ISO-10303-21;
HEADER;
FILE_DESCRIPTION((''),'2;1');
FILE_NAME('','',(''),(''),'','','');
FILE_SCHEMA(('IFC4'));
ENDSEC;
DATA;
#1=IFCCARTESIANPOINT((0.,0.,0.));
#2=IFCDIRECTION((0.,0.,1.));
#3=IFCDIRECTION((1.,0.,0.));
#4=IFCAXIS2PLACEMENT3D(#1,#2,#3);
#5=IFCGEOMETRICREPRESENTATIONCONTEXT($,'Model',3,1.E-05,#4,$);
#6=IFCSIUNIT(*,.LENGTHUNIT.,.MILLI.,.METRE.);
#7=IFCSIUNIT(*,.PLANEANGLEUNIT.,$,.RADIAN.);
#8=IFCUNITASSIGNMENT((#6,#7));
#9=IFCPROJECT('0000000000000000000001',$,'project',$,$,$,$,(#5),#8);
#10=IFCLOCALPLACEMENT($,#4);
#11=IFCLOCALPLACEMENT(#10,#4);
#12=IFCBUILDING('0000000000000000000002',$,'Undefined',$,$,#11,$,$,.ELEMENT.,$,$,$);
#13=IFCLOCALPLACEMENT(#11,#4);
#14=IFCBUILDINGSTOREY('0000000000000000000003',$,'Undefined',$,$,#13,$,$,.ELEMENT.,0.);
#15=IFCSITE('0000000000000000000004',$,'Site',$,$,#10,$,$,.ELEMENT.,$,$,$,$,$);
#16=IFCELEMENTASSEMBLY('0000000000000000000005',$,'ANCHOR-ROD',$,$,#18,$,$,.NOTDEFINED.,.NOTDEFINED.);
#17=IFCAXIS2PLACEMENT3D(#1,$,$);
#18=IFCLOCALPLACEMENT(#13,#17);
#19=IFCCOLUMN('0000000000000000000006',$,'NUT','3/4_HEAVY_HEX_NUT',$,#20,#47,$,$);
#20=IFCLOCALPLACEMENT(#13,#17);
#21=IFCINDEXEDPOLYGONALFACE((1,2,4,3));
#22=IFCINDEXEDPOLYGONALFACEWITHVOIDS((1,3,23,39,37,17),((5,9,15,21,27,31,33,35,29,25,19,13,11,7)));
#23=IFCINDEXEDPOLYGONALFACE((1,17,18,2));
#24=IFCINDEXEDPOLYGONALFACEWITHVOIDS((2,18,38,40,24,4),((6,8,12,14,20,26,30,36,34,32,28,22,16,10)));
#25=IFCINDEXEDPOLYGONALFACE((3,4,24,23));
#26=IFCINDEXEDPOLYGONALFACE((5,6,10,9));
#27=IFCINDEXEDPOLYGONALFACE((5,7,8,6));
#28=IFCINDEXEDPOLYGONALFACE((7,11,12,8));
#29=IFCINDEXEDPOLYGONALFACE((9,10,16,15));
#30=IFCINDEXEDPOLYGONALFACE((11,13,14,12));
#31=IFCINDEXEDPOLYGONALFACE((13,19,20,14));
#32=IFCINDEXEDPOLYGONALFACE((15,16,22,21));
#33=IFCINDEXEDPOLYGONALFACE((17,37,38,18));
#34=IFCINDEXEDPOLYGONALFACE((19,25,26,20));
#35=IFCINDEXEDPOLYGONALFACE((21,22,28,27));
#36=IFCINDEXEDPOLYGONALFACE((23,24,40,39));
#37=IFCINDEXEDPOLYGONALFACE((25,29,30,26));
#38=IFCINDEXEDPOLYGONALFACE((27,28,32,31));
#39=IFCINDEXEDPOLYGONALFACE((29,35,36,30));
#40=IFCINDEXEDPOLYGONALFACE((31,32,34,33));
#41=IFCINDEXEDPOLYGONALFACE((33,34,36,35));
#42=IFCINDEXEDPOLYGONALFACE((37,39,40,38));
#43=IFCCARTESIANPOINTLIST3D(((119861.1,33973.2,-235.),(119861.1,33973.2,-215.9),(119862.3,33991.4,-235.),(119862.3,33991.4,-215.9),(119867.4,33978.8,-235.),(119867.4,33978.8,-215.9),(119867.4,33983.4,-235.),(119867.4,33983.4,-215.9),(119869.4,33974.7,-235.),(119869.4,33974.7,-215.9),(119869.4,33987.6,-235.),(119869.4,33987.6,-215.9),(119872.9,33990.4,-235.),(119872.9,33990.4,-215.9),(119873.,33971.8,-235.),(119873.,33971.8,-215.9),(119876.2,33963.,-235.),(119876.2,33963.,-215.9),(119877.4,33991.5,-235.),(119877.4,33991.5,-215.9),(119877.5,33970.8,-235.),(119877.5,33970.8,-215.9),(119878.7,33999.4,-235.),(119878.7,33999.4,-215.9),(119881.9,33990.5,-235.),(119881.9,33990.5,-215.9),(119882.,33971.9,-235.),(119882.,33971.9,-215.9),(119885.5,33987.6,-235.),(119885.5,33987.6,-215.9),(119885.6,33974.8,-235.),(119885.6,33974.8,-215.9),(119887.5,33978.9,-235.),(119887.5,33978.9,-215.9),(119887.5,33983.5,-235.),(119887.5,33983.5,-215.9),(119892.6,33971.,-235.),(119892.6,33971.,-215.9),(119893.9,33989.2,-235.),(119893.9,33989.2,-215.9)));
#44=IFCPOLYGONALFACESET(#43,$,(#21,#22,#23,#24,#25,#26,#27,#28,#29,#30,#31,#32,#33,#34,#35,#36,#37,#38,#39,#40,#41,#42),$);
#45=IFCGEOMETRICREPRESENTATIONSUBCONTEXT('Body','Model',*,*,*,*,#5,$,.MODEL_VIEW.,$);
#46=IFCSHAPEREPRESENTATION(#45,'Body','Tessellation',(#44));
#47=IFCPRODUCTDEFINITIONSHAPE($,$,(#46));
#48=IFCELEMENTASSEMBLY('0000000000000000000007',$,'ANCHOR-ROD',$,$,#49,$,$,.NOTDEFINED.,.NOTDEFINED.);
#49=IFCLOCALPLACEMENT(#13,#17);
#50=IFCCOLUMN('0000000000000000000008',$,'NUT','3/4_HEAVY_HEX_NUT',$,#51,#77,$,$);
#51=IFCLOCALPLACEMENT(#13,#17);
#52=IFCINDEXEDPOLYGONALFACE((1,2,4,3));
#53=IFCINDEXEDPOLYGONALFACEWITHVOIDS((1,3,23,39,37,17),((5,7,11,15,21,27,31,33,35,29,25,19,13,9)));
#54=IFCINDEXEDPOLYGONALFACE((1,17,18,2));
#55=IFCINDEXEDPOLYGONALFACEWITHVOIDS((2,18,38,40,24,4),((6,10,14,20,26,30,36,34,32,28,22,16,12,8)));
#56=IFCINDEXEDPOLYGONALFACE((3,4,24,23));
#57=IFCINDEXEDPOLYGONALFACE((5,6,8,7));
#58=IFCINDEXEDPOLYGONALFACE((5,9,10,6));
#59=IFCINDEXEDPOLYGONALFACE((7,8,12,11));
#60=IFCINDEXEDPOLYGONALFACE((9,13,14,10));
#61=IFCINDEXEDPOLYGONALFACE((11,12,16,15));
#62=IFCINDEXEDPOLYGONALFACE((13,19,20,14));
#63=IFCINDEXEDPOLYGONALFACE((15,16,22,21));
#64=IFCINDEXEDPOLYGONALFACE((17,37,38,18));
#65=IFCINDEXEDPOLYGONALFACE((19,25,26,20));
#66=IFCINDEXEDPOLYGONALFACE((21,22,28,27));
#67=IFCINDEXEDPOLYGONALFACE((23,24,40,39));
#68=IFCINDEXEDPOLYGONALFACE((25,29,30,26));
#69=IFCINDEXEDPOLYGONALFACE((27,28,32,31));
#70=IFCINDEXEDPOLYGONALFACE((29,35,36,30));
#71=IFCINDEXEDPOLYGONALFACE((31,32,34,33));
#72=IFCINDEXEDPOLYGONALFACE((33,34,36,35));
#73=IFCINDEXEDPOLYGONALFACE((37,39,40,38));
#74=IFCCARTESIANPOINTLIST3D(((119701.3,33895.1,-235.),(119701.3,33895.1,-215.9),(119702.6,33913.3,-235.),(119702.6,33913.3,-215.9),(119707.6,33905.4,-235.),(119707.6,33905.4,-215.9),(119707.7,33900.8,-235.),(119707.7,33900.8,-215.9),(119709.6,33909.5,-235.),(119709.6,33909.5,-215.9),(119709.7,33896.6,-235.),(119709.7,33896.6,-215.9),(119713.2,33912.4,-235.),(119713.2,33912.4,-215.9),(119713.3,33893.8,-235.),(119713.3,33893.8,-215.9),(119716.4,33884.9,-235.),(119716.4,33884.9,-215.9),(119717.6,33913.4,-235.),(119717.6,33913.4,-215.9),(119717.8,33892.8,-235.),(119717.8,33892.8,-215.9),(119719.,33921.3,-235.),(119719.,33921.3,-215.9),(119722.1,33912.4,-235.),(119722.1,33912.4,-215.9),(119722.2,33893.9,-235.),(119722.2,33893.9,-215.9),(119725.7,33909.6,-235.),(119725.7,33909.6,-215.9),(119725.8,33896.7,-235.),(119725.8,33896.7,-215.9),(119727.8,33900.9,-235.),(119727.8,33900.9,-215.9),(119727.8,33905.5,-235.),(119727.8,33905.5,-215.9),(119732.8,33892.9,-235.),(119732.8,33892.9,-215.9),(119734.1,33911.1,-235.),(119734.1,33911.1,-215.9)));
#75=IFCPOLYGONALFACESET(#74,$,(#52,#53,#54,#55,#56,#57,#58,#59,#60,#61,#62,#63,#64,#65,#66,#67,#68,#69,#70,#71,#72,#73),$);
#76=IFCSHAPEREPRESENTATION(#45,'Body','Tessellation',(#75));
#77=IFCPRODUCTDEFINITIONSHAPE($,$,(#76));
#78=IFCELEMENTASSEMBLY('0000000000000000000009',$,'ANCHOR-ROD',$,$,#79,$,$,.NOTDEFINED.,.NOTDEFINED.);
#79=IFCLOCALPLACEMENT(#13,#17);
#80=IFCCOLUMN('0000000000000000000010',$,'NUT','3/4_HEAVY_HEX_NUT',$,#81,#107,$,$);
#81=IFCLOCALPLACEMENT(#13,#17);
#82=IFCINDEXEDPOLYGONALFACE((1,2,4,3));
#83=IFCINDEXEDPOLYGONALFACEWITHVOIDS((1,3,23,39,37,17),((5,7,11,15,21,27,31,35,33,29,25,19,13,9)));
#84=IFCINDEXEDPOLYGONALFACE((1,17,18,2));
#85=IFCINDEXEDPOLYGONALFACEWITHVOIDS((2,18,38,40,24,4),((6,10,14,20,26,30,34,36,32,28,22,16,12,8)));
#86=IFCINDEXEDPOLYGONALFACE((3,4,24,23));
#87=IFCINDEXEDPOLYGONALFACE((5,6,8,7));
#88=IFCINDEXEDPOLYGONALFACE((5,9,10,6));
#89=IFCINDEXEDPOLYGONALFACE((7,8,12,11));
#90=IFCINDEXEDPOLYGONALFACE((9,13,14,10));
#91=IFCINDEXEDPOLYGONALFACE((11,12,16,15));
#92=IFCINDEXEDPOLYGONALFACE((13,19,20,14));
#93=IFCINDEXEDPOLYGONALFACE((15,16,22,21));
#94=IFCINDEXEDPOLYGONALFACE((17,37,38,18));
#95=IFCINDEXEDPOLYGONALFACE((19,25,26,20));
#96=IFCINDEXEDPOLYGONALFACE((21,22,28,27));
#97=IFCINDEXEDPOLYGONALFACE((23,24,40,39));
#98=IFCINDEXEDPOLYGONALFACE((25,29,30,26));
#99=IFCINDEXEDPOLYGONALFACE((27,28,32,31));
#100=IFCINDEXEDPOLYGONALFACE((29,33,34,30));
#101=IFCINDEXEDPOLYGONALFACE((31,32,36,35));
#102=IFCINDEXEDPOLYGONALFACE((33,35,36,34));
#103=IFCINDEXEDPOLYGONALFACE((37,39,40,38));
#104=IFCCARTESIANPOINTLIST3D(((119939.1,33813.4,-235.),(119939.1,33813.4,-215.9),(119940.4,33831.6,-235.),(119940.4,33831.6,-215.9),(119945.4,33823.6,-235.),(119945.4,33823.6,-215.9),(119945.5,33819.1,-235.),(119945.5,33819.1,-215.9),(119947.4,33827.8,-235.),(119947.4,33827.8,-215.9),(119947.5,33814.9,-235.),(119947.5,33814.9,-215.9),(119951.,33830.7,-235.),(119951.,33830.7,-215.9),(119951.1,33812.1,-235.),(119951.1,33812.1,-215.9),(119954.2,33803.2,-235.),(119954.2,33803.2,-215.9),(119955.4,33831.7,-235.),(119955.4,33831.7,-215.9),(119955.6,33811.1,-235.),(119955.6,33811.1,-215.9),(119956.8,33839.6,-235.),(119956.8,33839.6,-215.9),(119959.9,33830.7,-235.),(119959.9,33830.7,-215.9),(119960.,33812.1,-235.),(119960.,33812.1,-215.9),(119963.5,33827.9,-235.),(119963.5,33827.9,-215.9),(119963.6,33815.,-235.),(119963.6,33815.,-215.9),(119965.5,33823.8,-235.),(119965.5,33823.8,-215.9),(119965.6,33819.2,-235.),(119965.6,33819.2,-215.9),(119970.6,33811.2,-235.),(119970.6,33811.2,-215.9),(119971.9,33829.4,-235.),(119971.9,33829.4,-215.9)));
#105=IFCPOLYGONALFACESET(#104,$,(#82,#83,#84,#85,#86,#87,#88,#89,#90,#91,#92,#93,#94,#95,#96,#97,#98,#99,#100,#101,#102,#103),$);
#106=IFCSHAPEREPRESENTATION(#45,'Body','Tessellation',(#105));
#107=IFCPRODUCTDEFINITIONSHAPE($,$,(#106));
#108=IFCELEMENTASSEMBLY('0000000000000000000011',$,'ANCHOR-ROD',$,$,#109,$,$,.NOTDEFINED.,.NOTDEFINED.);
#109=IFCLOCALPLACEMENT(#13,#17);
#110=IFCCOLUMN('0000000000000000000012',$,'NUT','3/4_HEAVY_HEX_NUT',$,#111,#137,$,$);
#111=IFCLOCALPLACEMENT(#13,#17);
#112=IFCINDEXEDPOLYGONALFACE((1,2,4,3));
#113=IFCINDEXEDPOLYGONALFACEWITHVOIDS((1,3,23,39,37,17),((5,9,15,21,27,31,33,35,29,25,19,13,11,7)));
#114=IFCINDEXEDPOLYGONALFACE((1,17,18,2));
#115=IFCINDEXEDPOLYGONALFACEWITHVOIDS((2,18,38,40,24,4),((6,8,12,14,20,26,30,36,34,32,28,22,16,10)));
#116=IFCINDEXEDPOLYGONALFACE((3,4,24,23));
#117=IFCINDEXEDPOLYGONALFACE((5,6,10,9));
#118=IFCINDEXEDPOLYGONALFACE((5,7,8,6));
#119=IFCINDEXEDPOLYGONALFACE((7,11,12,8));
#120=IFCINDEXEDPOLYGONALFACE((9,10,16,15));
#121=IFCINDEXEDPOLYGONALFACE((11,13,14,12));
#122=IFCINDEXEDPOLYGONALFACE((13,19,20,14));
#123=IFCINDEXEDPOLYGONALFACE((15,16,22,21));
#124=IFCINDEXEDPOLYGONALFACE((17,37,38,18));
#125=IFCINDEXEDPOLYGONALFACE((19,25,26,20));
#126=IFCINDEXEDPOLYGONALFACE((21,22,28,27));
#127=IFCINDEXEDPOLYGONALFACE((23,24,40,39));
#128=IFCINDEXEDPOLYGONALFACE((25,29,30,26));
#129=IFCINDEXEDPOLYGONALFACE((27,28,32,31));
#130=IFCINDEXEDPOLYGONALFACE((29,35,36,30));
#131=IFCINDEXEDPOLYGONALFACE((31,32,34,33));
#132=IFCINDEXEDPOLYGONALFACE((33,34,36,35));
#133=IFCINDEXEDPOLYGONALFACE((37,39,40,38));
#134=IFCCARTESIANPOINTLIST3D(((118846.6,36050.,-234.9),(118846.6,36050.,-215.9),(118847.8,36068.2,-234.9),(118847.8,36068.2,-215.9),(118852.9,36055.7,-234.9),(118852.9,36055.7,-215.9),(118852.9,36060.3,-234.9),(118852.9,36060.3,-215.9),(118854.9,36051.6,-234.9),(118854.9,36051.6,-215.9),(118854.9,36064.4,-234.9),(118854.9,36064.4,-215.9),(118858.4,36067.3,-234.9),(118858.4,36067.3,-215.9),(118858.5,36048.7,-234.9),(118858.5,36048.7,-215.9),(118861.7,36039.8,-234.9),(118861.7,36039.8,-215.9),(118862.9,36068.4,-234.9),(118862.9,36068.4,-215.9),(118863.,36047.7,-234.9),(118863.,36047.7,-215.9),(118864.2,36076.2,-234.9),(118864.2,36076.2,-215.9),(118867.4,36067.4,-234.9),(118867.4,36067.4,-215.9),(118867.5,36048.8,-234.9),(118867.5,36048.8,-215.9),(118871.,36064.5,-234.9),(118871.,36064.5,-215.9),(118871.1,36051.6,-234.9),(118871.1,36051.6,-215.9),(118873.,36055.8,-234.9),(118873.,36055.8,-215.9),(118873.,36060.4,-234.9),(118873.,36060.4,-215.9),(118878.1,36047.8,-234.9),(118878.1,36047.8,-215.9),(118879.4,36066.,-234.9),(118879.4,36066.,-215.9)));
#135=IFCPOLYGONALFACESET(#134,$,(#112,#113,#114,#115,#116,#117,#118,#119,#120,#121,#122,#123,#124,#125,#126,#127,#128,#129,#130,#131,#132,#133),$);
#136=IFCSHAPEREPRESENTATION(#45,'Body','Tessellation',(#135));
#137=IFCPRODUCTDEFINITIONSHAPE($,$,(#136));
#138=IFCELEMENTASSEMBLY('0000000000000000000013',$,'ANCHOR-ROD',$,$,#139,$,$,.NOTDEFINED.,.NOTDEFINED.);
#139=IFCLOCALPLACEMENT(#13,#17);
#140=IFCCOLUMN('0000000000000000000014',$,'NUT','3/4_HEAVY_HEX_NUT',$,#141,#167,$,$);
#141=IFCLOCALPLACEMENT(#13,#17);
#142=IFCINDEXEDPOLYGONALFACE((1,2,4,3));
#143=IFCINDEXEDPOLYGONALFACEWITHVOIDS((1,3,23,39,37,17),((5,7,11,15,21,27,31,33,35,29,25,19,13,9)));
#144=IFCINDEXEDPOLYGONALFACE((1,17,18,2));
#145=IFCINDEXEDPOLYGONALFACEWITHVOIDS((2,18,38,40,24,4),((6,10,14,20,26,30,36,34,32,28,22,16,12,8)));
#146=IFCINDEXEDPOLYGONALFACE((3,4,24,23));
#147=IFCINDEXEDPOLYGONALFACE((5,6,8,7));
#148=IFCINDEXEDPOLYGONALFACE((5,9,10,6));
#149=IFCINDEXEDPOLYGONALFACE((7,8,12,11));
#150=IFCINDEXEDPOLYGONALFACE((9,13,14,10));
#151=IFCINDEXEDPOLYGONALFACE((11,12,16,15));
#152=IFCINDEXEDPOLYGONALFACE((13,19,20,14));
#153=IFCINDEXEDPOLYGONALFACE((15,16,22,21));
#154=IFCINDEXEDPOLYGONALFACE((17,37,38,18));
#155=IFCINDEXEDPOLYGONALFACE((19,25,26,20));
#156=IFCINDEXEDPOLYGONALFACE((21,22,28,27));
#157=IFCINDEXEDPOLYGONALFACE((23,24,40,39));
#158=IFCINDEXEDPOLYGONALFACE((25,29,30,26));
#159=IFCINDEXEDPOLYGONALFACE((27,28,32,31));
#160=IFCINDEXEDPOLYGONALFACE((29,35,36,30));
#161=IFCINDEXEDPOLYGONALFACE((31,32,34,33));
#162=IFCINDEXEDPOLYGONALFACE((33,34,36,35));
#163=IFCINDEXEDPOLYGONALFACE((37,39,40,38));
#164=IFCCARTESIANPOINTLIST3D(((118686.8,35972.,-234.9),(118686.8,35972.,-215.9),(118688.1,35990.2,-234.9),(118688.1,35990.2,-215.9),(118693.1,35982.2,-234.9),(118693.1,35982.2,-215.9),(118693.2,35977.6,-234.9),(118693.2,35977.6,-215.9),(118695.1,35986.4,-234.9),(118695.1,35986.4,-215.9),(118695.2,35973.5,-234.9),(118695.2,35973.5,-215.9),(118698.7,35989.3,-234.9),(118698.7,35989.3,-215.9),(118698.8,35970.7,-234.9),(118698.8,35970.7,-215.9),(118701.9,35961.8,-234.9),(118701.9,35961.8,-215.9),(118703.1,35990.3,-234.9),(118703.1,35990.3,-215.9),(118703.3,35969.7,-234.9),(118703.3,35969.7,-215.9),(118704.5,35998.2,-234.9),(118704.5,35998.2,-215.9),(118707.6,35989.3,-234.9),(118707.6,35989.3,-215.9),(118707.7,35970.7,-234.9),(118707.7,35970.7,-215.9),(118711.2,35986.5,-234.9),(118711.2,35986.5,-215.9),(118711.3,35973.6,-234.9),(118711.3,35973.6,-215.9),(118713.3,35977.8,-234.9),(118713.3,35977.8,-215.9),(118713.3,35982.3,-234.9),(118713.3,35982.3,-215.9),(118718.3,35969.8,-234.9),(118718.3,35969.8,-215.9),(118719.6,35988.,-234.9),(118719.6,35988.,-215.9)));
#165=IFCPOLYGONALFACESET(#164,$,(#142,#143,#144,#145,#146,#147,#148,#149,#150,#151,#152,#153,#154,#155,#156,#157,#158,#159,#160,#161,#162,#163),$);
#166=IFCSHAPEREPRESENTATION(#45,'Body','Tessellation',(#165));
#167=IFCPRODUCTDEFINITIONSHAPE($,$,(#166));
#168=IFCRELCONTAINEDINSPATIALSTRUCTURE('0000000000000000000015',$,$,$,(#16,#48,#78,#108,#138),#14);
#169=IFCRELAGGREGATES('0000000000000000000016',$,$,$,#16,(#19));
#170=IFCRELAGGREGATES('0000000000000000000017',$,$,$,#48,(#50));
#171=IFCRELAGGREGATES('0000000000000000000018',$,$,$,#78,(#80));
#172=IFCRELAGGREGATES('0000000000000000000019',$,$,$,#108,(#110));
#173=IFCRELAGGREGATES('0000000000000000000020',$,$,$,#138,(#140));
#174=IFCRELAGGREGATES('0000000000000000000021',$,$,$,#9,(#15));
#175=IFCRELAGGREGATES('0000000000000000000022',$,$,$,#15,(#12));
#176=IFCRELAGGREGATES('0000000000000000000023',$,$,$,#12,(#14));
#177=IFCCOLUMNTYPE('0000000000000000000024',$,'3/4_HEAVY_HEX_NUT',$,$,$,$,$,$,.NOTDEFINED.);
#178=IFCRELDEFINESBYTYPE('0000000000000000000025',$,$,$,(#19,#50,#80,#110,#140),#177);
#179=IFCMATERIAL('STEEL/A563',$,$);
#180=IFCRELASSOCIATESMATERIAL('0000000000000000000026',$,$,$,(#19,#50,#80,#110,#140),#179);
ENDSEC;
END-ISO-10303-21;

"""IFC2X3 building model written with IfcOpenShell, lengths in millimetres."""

from ifc_helpers import new_model, si_unit, frame, origin_with_axes, place, context, subcontext, project, spatial, polyline, outline, extrude, material, type_object, element, aggregate, save


model = new_model("IFC2X3")

# Units and contexts
model_context = context("Model", 3, precision=1e-05, world=origin_with_axes())
body_context = subcontext(model_context, "Body", "Model", "MODEL_VIEW")
ifc_project = project(units=[si_unit("LENGTHUNIT", "METRE", prefix="MILLI"), si_unit("PLANEANGLEUNIT", "RADIAN")], contexts=[model_context])

# Site, building, storey
site_placement = place(None, origin_with_axes())
site = spatial("IfcSite", under=ifc_project, at=site_placement, Name="Site", CompositionType="ELEMENT")
building_placement = place(site_placement, origin_with_axes())
building = spatial("IfcBuilding", under=site, at=building_placement, Name="Undefined", CompositionType="ELEMENT")
storey_placement = place(building_placement, origin_with_axes())
storey = spatial("IfcBuildingStorey", under=building, at=storey_placement, Name="Undefined", CompositionType="ELEMENT", Elevation=0.0)

# Element assemblies, columns
assembly_1_placement = place(storey_placement, origin_with_axes())
assembly_1 = element("IfcElementAssembly", 1, at=assembly_1_placement, inside=storey, Name="ANCHOR-ROD", AssemblyPlace="NOTDEFINED", PredefinedType="NOTDEFINED")
ifc_material_1 = material(Name="STEEL/A563")
column_type_1 = type_object("IfcColumnType", Name="3/4_HEAVY_HEX_NUT", PredefinedType="NOTDEFINED")
column_1_placement = place(assembly_1_placement, frame((119877.5, 33981.2, -215.9), z_axis=(0.0, 0.0, -1.0), x_axis=(-0.438909, 0.898531, 0.0)))
column_1 = element("IfcColumn", 2, at=column_1_placement, type_object=column_type_1, material=ifc_material_1, Name="NUT", Description="3/4_HEAVY_HEX_NUT", context=body_context, shape_type="SweptSolid", body=[
    extrude(outline(polyline([(-9.1, 15.8), (9.1, 15.8), (18.3, 0.0), (9.1, -15.8), (-9.1, -15.8), (-18.3, 0.0), (-9.1, 15.8)]), holes=[polyline([(8.1, -6.4), (10.1, -2.3), (10.1, 2.3), (8.1, 6.4), (4.5, 9.3), (0.0, 10.3), (-4.5, 9.3), (-8.1, 6.4), (-10.1, 2.3), (-10.1, -2.3), (-8.1, -6.4), (-4.5, -9.3), (0.0, -10.3), (4.5, -9.3), (8.1, -6.4)])]), frame((0.0, 0.0, 19.1), z_axis=(0.0, 0.0, -1.0), x_axis=(0.0, 1.0, 0.0)), (0.0, 0.0, 1.0), 19.1),
])
aggregate(assembly_1, [column_1])
assembly_2_placement = place(storey_placement, origin_with_axes())
assembly_2 = element("IfcElementAssembly", 3, at=assembly_2_placement, inside=storey, Name="ANCHOR-ROD", AssemblyPlace="NOTDEFINED", PredefinedType="NOTDEFINED")
column_2_placement = place(assembly_2_placement, frame((119717.7, 33903.1, -215.9), z_axis=(0.0, 0.0, -1.0), x_axis=(0.438909, -0.898531, 0.0)))
column_2 = element("IfcColumn", 4, at=column_2_placement, type_object=column_type_1, material=ifc_material_1, Name="NUT", Description="3/4_HEAVY_HEX_NUT", context=body_context, shape_type="SweptSolid", body=[
    extrude(outline(polyline([(-9.1, 15.8), (9.1, 15.8), (18.3, 0.0), (9.1, -15.8), (-9.1, -15.8), (-18.3, 0.0), (-9.1, 15.8)]), holes=[polyline([(8.1, -6.4), (10.1, -2.3), (10.1, 2.3), (8.1, 6.4), (4.5, 9.3), (0.0, 10.3), (-4.5, 9.3), (-8.1, 6.4), (-10.1, 2.3), (-10.1, -2.3), (-8.1, -6.4), (-4.5, -9.3), (0.0, -10.3), (4.5, -9.3), (8.1, -6.4)])]), frame((0.0, 0.0, 19.1), z_axis=(0.0, 0.0, -1.0), x_axis=(0.0, 1.0, 0.0)), (0.0, 0.0, 1.0), 19.1),
])
aggregate(assembly_2, [column_2])
assembly_3_placement = place(storey_placement, origin_with_axes())
assembly_3 = element("IfcElementAssembly", 5, at=assembly_3_placement, inside=storey, Name="ANCHOR-ROD", AssemblyPlace="NOTDEFINED", PredefinedType="NOTDEFINED")
column_3_placement = place(assembly_3_placement, frame((119955.5, 33821.4, -215.9), z_axis=(0.0, 0.0, -1.0), x_axis=(-0.438909, 0.898531, 0.0)))
column_3 = element("IfcColumn", 6, at=column_3_placement, type_object=column_type_1, material=ifc_material_1, Name="NUT", Description="3/4_HEAVY_HEX_NUT", context=body_context, shape_type="SweptSolid", body=[
    extrude(outline(polyline([(-9.1, 15.8), (9.1, 15.8), (18.3, 0.0), (9.1, -15.8), (-9.1, -15.8), (-18.3, 0.0), (-9.1, 15.8)]), holes=[polyline([(8.1, -6.4), (10.1, -2.3), (10.1, 2.3), (8.1, 6.4), (4.5, 9.3), (0.0, 10.3), (-4.5, 9.3), (-8.1, 6.4), (-10.1, 2.3), (-10.1, -2.3), (-8.1, -6.4), (-4.5, -9.3), (0.0, -10.3), (4.5, -9.3), (8.1, -6.4)])]), frame((0.0, 0.0, 19.1), z_axis=(0.0, 0.0, -1.0), x_axis=(0.0, 1.0, 0.0)), (0.0, 0.0, 1.0), 19.1),
])
aggregate(assembly_3, [column_3])
assembly_4_placement = place(storey_placement, origin_with_axes())
assembly_4 = element("IfcElementAssembly", 7, at=assembly_4_placement, inside=storey, Name="ANCHOR-ROD", AssemblyPlace="NOTDEFINED", PredefinedType="NOTDEFINED")
column_4_placement = place(assembly_4_placement, frame((118863.0, 36058.0, -215.9), z_axis=(0.0, 0.0, -1.0), x_axis=(-0.438909, 0.898531, 0.0)))
column_4 = element("IfcColumn", 8, at=column_4_placement, type_object=column_type_1, material=ifc_material_1, Name="NUT", Description="3/4_HEAVY_HEX_NUT", context=body_context, shape_type="SweptSolid", body=[
    extrude(outline(polyline([(-9.1, 15.8), (9.1, 15.8), (18.3, 0.0), (9.1, -15.8), (-9.1, -15.8), (-18.3, 0.0), (-9.1, 15.8)]), holes=[polyline([(8.1, -6.4), (10.1, -2.3), (10.1, 2.3), (8.1, 6.4), (4.5, 9.3), (0.0, 10.3), (-4.5, 9.3), (-8.1, 6.4), (-10.1, 2.3), (-10.1, -2.3), (-8.1, -6.4), (-4.5, -9.3), (0.0, -10.3), (4.5, -9.3), (8.1, -6.4)])]), frame((0.0, 0.0, 19.1), z_axis=(0.0, 0.0, -1.0), x_axis=(0.0, 1.0, 0.0)), (0.0, 0.0, 1.0), 19.1),
])
assembly_5_placement = place(storey_placement, origin_with_axes())
assembly_5 = element("IfcElementAssembly", 9, at=assembly_5_placement, inside=storey, Name="ANCHOR-ROD", AssemblyPlace="NOTDEFINED", PredefinedType="NOTDEFINED")
column_5_placement = place(assembly_5_placement, frame((118703.2, 35980.0, -215.9), z_axis=(0.0, 0.0, -1.0), x_axis=(0.438909, -0.898531, 0.0)))
column_5 = element("IfcColumn", 10, at=column_5_placement, type_object=column_type_1, material=ifc_material_1, Name="NUT", Description="3/4_HEAVY_HEX_NUT", context=body_context, shape_type="SweptSolid", body=[
    extrude(outline(polyline([(-9.1, 15.8), (9.1, 15.8), (18.3, 0.0), (9.1, -15.8), (-9.1, -15.8), (-18.3, 0.0), (-9.1, 15.8)]), holes=[polyline([(8.1, -6.4), (10.1, -2.3), (10.1, 2.3), (8.1, 6.4), (4.5, 9.3), (0.0, 10.3), (-4.5, 9.3), (-8.1, 6.4), (-10.1, 2.3), (-10.1, -2.3), (-8.1, -6.4), (-4.5, -9.3), (0.0, -10.3), (4.5, -9.3), (8.1, -6.4)])]), frame((0.0, 0.0, 19.1), z_axis=(0.0, 0.0, -1.0), x_axis=(0.0, 1.0, 0.0)), (0.0, 0.0, 1.0), 19.1),
])

aggregate(assembly_4, [column_4])
aggregate(assembly_5, [column_5])

save(model, "model.ifc")
